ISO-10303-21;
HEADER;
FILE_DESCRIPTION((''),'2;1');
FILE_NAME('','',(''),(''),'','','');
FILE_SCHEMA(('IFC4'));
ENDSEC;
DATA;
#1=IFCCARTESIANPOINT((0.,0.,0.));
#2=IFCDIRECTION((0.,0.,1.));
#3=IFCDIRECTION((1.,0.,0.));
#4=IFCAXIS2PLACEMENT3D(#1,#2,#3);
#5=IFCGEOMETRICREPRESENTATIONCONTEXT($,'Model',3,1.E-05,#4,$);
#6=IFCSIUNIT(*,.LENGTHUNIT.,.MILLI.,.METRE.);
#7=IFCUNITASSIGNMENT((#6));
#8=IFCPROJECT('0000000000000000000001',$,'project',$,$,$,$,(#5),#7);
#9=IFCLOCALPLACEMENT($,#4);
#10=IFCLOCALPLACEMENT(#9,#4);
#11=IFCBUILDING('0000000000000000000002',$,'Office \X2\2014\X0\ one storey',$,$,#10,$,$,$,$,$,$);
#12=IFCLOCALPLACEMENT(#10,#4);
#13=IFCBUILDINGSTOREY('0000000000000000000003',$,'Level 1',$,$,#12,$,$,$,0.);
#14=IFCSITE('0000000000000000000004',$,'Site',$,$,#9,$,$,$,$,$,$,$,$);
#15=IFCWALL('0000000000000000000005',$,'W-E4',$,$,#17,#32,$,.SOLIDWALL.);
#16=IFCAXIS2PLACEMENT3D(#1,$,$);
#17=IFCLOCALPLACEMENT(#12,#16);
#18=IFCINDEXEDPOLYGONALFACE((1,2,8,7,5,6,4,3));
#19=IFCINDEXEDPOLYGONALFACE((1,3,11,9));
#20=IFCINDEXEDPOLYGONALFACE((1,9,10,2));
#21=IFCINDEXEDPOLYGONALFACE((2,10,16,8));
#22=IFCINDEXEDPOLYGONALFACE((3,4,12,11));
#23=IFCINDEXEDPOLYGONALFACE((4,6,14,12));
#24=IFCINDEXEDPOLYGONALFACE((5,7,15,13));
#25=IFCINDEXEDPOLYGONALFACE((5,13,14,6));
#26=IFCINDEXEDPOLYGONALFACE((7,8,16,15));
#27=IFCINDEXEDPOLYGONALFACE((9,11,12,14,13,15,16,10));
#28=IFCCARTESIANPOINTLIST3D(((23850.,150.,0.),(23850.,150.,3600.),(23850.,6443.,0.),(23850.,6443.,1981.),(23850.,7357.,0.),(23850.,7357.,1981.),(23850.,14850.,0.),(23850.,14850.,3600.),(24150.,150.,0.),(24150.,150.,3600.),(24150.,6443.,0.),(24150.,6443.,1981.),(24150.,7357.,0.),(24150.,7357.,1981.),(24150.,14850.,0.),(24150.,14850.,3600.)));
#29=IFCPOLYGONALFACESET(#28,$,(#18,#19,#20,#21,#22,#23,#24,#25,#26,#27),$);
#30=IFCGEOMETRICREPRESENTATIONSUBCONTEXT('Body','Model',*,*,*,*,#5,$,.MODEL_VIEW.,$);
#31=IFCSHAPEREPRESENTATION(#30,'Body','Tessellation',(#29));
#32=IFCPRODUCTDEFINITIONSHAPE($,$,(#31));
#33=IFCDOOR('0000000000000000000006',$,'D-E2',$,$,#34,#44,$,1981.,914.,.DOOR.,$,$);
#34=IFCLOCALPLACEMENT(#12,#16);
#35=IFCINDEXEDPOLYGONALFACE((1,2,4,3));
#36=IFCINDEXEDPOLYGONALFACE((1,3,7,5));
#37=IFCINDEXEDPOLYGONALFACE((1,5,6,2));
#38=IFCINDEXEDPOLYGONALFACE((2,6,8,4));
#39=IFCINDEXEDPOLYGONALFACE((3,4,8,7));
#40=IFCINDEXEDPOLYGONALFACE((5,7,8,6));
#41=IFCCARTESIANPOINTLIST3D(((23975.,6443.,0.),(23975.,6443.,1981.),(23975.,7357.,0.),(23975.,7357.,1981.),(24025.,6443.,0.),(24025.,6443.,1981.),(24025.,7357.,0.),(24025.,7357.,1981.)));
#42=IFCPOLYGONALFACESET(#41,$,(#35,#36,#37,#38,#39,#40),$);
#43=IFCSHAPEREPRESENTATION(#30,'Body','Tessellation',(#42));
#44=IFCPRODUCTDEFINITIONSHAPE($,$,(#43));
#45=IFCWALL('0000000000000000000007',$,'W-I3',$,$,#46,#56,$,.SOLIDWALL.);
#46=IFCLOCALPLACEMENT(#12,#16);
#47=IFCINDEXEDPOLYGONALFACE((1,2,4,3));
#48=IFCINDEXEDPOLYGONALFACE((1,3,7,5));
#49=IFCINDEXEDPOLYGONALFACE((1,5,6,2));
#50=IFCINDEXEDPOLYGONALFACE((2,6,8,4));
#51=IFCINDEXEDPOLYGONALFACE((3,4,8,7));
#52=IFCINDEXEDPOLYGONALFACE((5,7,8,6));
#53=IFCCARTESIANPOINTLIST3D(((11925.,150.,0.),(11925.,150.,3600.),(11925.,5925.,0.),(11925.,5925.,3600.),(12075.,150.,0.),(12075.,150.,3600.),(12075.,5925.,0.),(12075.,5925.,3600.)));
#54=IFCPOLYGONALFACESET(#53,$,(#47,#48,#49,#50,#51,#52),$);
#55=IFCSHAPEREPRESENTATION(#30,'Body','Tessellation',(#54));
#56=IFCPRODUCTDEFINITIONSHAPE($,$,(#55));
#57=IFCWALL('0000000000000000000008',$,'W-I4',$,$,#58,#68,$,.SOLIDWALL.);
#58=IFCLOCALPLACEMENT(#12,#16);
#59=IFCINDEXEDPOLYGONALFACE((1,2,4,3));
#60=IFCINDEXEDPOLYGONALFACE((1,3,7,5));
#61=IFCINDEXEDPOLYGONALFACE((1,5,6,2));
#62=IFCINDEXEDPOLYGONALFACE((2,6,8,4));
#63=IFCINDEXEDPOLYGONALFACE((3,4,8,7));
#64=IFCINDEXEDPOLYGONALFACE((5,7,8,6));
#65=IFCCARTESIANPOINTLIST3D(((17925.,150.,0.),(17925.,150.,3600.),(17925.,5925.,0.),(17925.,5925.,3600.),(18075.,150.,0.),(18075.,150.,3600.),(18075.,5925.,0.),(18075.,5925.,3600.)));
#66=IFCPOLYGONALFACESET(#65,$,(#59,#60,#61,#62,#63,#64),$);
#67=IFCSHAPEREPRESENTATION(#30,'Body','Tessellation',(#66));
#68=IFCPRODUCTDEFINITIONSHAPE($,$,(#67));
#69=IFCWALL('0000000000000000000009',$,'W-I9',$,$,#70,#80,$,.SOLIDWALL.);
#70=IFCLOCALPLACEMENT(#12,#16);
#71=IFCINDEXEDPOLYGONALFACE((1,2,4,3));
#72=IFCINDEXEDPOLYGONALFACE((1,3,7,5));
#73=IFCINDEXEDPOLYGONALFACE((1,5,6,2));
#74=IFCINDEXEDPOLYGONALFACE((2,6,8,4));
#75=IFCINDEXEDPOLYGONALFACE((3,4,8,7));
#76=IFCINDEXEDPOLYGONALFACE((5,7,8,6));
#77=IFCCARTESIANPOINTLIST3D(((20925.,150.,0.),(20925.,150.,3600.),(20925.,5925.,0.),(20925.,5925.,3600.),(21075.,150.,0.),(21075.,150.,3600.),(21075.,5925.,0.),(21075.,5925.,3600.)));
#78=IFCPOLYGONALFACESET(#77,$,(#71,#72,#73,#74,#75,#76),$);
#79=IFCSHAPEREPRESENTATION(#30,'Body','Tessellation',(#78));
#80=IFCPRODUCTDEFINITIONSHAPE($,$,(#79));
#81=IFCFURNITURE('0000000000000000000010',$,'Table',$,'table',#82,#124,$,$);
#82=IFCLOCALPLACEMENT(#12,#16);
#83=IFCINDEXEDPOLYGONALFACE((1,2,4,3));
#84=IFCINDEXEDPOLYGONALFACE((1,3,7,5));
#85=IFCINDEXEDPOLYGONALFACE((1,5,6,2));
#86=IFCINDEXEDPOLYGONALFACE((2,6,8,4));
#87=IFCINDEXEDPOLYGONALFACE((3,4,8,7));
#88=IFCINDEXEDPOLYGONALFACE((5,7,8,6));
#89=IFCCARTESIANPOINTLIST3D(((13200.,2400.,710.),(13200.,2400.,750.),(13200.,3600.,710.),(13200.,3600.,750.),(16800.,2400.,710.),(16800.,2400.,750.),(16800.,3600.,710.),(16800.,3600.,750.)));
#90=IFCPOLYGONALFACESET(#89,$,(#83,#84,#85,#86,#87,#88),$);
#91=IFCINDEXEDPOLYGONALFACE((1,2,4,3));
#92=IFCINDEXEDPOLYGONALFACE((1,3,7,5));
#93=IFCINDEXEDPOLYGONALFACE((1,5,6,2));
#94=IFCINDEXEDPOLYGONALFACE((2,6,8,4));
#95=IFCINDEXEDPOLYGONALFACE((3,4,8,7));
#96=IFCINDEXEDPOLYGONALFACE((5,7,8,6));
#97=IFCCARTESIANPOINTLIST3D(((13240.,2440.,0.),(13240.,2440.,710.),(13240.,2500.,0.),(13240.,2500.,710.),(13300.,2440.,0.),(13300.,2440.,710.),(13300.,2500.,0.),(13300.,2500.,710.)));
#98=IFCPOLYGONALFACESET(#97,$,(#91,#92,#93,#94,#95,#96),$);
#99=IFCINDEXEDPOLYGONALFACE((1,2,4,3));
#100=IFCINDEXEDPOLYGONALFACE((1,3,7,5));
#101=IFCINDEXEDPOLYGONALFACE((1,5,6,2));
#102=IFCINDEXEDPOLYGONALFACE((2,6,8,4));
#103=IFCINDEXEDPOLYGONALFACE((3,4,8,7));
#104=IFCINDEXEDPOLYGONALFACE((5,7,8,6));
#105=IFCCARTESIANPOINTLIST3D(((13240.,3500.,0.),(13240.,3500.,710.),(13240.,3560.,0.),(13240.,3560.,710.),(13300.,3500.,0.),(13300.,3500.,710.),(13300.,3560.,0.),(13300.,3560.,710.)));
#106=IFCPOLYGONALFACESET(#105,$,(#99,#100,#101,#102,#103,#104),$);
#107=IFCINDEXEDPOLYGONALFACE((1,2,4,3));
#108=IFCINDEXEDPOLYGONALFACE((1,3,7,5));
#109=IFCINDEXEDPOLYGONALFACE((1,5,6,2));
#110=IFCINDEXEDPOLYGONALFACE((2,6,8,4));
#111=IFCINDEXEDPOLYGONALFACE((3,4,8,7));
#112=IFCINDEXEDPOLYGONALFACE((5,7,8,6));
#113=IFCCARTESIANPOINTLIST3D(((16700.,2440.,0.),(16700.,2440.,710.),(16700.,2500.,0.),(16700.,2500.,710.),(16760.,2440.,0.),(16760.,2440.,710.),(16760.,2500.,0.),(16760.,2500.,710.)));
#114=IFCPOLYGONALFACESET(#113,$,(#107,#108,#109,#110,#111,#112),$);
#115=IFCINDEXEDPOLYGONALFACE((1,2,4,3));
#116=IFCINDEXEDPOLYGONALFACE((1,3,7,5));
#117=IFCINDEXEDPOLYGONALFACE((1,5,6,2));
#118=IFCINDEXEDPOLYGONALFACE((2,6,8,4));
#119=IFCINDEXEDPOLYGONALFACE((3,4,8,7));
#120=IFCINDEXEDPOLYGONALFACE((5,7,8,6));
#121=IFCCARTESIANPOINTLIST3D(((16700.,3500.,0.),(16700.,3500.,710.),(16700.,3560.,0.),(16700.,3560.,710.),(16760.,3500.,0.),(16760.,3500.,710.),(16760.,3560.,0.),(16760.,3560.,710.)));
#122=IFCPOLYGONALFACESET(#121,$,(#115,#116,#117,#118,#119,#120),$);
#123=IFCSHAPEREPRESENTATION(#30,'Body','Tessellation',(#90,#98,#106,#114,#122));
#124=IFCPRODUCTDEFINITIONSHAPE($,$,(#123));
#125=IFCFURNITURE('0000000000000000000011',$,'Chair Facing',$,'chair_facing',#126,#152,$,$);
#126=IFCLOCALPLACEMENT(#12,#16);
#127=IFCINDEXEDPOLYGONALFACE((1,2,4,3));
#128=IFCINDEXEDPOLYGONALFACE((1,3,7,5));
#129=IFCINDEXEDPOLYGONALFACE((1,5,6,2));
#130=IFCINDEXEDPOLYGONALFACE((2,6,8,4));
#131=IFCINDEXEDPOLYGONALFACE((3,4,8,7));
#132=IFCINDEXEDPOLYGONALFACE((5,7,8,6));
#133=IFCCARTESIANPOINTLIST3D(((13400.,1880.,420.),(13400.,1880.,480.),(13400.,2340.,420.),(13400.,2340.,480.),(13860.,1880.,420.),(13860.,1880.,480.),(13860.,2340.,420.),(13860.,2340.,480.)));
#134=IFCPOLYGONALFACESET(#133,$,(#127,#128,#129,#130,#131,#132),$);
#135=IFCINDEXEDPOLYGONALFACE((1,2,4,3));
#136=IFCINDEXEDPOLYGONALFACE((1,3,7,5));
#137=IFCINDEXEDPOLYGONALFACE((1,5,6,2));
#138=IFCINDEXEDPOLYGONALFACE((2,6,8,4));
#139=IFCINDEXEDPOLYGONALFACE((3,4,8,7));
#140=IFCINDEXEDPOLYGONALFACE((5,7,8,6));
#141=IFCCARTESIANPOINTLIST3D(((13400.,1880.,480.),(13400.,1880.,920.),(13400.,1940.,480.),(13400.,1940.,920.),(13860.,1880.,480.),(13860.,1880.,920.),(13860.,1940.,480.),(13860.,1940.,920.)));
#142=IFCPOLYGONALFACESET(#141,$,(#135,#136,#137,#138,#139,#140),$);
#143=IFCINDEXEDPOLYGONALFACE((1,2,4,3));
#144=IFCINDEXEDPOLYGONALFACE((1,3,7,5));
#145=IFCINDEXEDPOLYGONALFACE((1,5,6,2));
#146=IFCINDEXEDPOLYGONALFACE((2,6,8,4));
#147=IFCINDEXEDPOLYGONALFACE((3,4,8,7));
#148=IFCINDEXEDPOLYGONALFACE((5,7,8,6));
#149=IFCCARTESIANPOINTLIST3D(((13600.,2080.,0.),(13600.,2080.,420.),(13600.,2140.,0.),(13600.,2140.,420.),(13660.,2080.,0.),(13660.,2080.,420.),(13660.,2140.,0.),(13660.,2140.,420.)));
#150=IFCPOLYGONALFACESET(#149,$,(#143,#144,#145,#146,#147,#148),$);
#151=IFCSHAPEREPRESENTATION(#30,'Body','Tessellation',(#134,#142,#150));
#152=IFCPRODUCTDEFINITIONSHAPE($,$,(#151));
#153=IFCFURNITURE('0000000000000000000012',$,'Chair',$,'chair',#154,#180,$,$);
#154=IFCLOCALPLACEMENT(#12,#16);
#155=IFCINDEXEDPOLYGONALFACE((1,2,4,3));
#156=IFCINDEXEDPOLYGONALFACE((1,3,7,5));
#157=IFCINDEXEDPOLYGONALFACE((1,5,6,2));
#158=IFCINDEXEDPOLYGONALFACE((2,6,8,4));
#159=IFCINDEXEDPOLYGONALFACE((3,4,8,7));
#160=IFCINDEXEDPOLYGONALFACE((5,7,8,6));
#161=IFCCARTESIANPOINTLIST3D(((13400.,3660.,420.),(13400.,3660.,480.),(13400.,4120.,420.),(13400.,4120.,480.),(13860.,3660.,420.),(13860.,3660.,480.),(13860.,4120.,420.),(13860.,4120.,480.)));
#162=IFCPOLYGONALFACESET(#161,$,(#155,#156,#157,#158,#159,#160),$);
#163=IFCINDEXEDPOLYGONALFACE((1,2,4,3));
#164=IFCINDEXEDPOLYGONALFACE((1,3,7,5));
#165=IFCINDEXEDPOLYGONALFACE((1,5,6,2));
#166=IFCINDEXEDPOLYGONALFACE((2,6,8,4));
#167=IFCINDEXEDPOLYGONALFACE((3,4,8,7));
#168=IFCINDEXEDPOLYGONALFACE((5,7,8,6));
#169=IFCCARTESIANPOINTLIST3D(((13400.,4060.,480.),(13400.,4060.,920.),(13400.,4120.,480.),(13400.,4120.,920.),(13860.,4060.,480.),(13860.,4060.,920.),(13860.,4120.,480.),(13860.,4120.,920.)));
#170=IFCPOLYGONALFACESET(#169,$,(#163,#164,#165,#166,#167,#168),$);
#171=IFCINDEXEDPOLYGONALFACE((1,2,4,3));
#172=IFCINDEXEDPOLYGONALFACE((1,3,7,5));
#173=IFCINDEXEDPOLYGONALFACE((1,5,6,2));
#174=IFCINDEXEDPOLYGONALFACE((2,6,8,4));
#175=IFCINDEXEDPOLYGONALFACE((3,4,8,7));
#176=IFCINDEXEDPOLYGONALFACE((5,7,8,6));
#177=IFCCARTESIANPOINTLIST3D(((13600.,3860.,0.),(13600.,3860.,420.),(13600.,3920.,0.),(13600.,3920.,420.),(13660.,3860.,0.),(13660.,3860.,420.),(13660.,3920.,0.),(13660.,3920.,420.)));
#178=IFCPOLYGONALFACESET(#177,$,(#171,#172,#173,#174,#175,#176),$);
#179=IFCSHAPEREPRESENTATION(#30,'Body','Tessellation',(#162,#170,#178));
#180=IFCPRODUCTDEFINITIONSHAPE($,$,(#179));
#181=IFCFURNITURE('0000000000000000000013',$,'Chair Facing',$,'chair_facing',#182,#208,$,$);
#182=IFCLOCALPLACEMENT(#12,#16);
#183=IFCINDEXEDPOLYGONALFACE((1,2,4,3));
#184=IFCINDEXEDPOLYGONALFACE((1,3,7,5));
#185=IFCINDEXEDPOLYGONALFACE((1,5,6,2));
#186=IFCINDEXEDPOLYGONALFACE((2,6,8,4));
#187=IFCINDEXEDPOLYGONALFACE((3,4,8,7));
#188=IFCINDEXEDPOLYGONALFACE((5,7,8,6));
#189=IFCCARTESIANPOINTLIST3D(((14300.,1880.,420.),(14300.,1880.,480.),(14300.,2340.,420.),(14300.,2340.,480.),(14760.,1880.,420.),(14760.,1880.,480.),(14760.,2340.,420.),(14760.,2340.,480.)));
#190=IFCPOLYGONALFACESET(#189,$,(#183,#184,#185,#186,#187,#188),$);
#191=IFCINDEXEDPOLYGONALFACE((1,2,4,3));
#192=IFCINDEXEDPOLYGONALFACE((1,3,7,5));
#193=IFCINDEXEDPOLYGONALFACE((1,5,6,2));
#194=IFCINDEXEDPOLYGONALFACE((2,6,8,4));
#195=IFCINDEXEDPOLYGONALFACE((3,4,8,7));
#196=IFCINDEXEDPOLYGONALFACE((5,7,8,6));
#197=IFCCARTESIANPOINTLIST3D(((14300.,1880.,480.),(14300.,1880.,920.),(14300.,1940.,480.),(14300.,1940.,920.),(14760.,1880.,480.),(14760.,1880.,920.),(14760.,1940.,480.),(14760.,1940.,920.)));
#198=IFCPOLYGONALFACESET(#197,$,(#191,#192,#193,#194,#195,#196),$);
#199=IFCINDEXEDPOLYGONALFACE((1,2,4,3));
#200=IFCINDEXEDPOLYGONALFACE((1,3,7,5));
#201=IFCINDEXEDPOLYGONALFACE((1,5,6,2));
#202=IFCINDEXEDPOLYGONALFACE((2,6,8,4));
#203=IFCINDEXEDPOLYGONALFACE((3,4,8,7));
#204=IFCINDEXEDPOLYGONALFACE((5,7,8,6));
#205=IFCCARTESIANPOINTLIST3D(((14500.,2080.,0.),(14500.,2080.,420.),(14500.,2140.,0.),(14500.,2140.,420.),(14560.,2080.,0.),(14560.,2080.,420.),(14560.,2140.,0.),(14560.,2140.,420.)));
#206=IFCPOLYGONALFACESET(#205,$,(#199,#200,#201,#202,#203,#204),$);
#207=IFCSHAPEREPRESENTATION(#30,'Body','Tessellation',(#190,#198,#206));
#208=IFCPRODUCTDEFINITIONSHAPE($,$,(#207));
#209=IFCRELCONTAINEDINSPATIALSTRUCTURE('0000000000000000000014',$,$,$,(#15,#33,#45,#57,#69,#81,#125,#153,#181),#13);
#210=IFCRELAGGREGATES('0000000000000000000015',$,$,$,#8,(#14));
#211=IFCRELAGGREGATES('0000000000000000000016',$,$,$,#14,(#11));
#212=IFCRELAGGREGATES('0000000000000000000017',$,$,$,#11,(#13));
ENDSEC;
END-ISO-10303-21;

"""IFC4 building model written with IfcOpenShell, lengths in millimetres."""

from ifc_helpers import new_model, si_unit, frame, frame_2d, origin, origin_with_axes, place, context, subcontext, project, spatial, rectangle, extrude, element, fill, save


model = new_model("IFC4")

# Units and contexts
model_context = context("Model", 3, precision=1e-05, world=origin_with_axes())
body_context = subcontext(model_context, "Body", "Model", "MODEL_VIEW")
ifc_project = project(units=[si_unit("LENGTHUNIT", "METRE", prefix="MILLI")], contexts=[model_context])

# Site, building, storey
site_placement = place(None, origin_with_axes())
site = spatial("IfcSite", under=ifc_project, at=site_placement, Name="Site")
building_placement = place(site_placement, origin_with_axes())
building = spatial("IfcBuilding", under=site, at=building_placement, Name="Office — one storey")
storey_placement = place(building_placement, origin_with_axes())
storey = spatial("IfcBuildingStorey", under=building, at=storey_placement, Name="Level 1", Elevation=0.0)

# Wall, opening, door
wall_1_placement = place(storey_placement, frame((23850.0, 0.0, 0.0), z_axis=(0.0, 0.0, 1.0), x_axis=(1.0, 0.0, 0.0)))
wall_1 = element("IfcWall", 1, at=wall_1_placement, inside=storey, Name="W-E4", PredefinedType="SOLIDWALL", context=body_context, shape_type="SweptSolid", body=[
    extrude(rectangle(XDim=300.0, YDim=14700.0, at=frame_2d((150.0, 7500.0))), origin(), (0.0, 0.0, 1.0), 3600.0),
])
opening_1_placement = place(wall_1_placement, frame((-10.0, 6443.0, 0.0), z_axis=(0.0, 0.0, 1.0), x_axis=(1.0, 0.0, 0.0)))
opening_1 = element("IfcOpeningElement", 2, at=opening_1_placement, cuts=wall_1, context=body_context, shape_type="SweptSolid", body=[
    extrude(rectangle(XDim=320.0, YDim=914.0, at=frame_2d((160.0, 457.0))), origin(), (0.0, 0.0, 1.0), 1981.0),
])
door_1_placement = place(storey_placement, frame((23975.0, 6443.0, 0.0), z_axis=(0.0, 0.0, 1.0), x_axis=(1.0, 0.0, 0.0)))
door_1 = element("IfcDoor", 3, at=door_1_placement, inside=storey, Name="D-E2", OverallHeight=1981.0, OverallWidth=914.0, PredefinedType="DOOR", context=body_context, shape_type="SweptSolid", body=[
    extrude(rectangle(XDim=50.0, YDim=914.0, at=frame_2d((25.0, 457.0))), origin(), (0.0, 0.0, 1.0), 1981.0),
])
fill(opening_1, door_1)

# Walls
for number, where, z_axis, x_axis, name in (
    (4, (11925.0, 0.0, 0.0), (0.0, 0.0, 1.0), (1.0, 0.0, 0.0), "W-I3"),
    (5, (17925.0, 0.0, 0.0), (0.0, 0.0, 1.0), (1.0, 0.0, 0.0), "W-I4"),
):
    element("IfcWall", number, at=place(storey_placement, frame(where, z_axis=z_axis, x_axis=x_axis)), inside=storey, Name=name, PredefinedType="SOLIDWALL", context=body_context, shape_type="SweptSolid", body=[
        extrude(rectangle(XDim=150.0, YDim=5775.0, at=frame_2d((75.0, 3037.5))), origin(), (0.0, 0.0, 1.0), 3600.0),
    ])
wall_2_placement = place(storey_placement, frame((20925.0, 0.0, 0.0), z_axis=(0.0, 0.0, 1.0), x_axis=(1.0, 0.0, 0.0)))
element("IfcWall", 6, at=wall_2_placement, inside=storey, Name="W-I9", PredefinedType="SOLIDWALL", context=body_context, shape_type="SweptSolid", body=[
    extrude(rectangle(XDim=150.0, YDim=5775.0, at=frame_2d((75.0, 3037.5))), origin(), (0.0, 0.0, 1.0), 3600.0),
])

# Furniture
furniture_1_placement = place(storey_placement, frame((13200.0, 2400.0, 0.0), z_axis=(0.0, 0.0, 1.0), x_axis=(1.0, 0.0, 0.0)))
element("IfcFurniture", 7, at=furniture_1_placement, inside=storey, Name="Table", ObjectType="table", context=body_context, shape_type="SweptSolid", body=[
    extrude(rectangle(XDim=3600.0, YDim=1200.0, at=frame_2d((1800.0, 600.0))), frame((0.0, 0.0, 710.0)), (0.0, 0.0, 1.0), 40.0),
    extrude(rectangle(XDim=60.0, YDim=60.0, at=frame_2d((70.0, 70.0))), origin(), (0.0, 0.0, 1.0), 710.0),
    extrude(rectangle(XDim=60.0, YDim=60.0, at=frame_2d((70.0, 1130.0))), origin(), (0.0, 0.0, 1.0), 710.0),
    extrude(rectangle(XDim=60.0, YDim=60.0, at=frame_2d((3530.0, 70.0))), origin(), (0.0, 0.0, 1.0), 710.0),
    extrude(rectangle(XDim=60.0, YDim=60.0, at=frame_2d((3530.0, 1130.0))), origin(), (0.0, 0.0, 1.0), 710.0),
])
furniture_2_placement = place(storey_placement, frame((13400.0, 1880.0, 0.0), z_axis=(0.0, 0.0, 1.0), x_axis=(1.0, 0.0, 0.0)))
element("IfcFurniture", 8, at=furniture_2_placement, inside=storey, Name="Chair Facing", ObjectType="chair_facing", context=body_context, shape_type="SweptSolid", body=[
    extrude(rectangle(XDim=460.0, YDim=460.0, at=frame_2d((230.0, 230.0))), frame((0.0, 0.0, 420.0)), (0.0, 0.0, 1.0), 60.0),
    extrude(rectangle(XDim=460.0, YDim=60.0, at=frame_2d((230.0, 30.0))), frame((0.0, 0.0, 480.0)), (0.0, 0.0, 1.0), 440.0),
    extrude(rectangle(XDim=60.0, YDim=60.0, at=frame_2d((230.0, 230.0))), origin(), (0.0, 0.0, 1.0), 420.0),
])
furniture_3_placement = place(storey_placement, frame((13400.0, 3660.0, 0.0), z_axis=(0.0, 0.0, 1.0), x_axis=(1.0, 0.0, 0.0)))
element("IfcFurniture", 9, at=furniture_3_placement, inside=storey, Name="Chair", ObjectType="chair", context=body_context, shape_type="SweptSolid", body=[
    extrude(rectangle(XDim=460.0, YDim=460.0, at=frame_2d((230.0, 230.0))), frame((0.0, 0.0, 420.0)), (0.0, 0.0, 1.0), 60.0),
    extrude(rectangle(XDim=460.0, YDim=60.0, at=frame_2d((230.0, 430.0))), frame((0.0, 0.0, 480.0)), (0.0, 0.0, 1.0), 440.0),
    extrude(rectangle(XDim=60.0, YDim=60.0, at=frame_2d((230.0, 230.0))), origin(), (0.0, 0.0, 1.0), 420.0),
])
furniture_4_placement = place(storey_placement, frame((14300.0, 1880.0, 0.0), z_axis=(0.0, 0.0, 1.0), x_axis=(1.0, 0.0, 0.0)))
element("IfcFurniture", 10, at=furniture_4_placement, inside=storey, Name="Chair Facing", ObjectType="chair_facing", context=body_context, shape_type="SweptSolid", body=[
    extrude(rectangle(XDim=460.0, YDim=460.0, at=frame_2d((230.0, 230.0))), frame((0.0, 0.0, 420.0)), (0.0, 0.0, 1.0), 60.0),
    extrude(rectangle(XDim=460.0, YDim=60.0, at=frame_2d((230.0, 30.0))), frame((0.0, 0.0, 480.0)), (0.0, 0.0, 1.0), 440.0),
    extrude(rectangle(XDim=60.0, YDim=60.0, at=frame_2d((230.0, 230.0))), origin(), (0.0, 0.0, 1.0), 420.0),
])

save(model, "model.ifc")
